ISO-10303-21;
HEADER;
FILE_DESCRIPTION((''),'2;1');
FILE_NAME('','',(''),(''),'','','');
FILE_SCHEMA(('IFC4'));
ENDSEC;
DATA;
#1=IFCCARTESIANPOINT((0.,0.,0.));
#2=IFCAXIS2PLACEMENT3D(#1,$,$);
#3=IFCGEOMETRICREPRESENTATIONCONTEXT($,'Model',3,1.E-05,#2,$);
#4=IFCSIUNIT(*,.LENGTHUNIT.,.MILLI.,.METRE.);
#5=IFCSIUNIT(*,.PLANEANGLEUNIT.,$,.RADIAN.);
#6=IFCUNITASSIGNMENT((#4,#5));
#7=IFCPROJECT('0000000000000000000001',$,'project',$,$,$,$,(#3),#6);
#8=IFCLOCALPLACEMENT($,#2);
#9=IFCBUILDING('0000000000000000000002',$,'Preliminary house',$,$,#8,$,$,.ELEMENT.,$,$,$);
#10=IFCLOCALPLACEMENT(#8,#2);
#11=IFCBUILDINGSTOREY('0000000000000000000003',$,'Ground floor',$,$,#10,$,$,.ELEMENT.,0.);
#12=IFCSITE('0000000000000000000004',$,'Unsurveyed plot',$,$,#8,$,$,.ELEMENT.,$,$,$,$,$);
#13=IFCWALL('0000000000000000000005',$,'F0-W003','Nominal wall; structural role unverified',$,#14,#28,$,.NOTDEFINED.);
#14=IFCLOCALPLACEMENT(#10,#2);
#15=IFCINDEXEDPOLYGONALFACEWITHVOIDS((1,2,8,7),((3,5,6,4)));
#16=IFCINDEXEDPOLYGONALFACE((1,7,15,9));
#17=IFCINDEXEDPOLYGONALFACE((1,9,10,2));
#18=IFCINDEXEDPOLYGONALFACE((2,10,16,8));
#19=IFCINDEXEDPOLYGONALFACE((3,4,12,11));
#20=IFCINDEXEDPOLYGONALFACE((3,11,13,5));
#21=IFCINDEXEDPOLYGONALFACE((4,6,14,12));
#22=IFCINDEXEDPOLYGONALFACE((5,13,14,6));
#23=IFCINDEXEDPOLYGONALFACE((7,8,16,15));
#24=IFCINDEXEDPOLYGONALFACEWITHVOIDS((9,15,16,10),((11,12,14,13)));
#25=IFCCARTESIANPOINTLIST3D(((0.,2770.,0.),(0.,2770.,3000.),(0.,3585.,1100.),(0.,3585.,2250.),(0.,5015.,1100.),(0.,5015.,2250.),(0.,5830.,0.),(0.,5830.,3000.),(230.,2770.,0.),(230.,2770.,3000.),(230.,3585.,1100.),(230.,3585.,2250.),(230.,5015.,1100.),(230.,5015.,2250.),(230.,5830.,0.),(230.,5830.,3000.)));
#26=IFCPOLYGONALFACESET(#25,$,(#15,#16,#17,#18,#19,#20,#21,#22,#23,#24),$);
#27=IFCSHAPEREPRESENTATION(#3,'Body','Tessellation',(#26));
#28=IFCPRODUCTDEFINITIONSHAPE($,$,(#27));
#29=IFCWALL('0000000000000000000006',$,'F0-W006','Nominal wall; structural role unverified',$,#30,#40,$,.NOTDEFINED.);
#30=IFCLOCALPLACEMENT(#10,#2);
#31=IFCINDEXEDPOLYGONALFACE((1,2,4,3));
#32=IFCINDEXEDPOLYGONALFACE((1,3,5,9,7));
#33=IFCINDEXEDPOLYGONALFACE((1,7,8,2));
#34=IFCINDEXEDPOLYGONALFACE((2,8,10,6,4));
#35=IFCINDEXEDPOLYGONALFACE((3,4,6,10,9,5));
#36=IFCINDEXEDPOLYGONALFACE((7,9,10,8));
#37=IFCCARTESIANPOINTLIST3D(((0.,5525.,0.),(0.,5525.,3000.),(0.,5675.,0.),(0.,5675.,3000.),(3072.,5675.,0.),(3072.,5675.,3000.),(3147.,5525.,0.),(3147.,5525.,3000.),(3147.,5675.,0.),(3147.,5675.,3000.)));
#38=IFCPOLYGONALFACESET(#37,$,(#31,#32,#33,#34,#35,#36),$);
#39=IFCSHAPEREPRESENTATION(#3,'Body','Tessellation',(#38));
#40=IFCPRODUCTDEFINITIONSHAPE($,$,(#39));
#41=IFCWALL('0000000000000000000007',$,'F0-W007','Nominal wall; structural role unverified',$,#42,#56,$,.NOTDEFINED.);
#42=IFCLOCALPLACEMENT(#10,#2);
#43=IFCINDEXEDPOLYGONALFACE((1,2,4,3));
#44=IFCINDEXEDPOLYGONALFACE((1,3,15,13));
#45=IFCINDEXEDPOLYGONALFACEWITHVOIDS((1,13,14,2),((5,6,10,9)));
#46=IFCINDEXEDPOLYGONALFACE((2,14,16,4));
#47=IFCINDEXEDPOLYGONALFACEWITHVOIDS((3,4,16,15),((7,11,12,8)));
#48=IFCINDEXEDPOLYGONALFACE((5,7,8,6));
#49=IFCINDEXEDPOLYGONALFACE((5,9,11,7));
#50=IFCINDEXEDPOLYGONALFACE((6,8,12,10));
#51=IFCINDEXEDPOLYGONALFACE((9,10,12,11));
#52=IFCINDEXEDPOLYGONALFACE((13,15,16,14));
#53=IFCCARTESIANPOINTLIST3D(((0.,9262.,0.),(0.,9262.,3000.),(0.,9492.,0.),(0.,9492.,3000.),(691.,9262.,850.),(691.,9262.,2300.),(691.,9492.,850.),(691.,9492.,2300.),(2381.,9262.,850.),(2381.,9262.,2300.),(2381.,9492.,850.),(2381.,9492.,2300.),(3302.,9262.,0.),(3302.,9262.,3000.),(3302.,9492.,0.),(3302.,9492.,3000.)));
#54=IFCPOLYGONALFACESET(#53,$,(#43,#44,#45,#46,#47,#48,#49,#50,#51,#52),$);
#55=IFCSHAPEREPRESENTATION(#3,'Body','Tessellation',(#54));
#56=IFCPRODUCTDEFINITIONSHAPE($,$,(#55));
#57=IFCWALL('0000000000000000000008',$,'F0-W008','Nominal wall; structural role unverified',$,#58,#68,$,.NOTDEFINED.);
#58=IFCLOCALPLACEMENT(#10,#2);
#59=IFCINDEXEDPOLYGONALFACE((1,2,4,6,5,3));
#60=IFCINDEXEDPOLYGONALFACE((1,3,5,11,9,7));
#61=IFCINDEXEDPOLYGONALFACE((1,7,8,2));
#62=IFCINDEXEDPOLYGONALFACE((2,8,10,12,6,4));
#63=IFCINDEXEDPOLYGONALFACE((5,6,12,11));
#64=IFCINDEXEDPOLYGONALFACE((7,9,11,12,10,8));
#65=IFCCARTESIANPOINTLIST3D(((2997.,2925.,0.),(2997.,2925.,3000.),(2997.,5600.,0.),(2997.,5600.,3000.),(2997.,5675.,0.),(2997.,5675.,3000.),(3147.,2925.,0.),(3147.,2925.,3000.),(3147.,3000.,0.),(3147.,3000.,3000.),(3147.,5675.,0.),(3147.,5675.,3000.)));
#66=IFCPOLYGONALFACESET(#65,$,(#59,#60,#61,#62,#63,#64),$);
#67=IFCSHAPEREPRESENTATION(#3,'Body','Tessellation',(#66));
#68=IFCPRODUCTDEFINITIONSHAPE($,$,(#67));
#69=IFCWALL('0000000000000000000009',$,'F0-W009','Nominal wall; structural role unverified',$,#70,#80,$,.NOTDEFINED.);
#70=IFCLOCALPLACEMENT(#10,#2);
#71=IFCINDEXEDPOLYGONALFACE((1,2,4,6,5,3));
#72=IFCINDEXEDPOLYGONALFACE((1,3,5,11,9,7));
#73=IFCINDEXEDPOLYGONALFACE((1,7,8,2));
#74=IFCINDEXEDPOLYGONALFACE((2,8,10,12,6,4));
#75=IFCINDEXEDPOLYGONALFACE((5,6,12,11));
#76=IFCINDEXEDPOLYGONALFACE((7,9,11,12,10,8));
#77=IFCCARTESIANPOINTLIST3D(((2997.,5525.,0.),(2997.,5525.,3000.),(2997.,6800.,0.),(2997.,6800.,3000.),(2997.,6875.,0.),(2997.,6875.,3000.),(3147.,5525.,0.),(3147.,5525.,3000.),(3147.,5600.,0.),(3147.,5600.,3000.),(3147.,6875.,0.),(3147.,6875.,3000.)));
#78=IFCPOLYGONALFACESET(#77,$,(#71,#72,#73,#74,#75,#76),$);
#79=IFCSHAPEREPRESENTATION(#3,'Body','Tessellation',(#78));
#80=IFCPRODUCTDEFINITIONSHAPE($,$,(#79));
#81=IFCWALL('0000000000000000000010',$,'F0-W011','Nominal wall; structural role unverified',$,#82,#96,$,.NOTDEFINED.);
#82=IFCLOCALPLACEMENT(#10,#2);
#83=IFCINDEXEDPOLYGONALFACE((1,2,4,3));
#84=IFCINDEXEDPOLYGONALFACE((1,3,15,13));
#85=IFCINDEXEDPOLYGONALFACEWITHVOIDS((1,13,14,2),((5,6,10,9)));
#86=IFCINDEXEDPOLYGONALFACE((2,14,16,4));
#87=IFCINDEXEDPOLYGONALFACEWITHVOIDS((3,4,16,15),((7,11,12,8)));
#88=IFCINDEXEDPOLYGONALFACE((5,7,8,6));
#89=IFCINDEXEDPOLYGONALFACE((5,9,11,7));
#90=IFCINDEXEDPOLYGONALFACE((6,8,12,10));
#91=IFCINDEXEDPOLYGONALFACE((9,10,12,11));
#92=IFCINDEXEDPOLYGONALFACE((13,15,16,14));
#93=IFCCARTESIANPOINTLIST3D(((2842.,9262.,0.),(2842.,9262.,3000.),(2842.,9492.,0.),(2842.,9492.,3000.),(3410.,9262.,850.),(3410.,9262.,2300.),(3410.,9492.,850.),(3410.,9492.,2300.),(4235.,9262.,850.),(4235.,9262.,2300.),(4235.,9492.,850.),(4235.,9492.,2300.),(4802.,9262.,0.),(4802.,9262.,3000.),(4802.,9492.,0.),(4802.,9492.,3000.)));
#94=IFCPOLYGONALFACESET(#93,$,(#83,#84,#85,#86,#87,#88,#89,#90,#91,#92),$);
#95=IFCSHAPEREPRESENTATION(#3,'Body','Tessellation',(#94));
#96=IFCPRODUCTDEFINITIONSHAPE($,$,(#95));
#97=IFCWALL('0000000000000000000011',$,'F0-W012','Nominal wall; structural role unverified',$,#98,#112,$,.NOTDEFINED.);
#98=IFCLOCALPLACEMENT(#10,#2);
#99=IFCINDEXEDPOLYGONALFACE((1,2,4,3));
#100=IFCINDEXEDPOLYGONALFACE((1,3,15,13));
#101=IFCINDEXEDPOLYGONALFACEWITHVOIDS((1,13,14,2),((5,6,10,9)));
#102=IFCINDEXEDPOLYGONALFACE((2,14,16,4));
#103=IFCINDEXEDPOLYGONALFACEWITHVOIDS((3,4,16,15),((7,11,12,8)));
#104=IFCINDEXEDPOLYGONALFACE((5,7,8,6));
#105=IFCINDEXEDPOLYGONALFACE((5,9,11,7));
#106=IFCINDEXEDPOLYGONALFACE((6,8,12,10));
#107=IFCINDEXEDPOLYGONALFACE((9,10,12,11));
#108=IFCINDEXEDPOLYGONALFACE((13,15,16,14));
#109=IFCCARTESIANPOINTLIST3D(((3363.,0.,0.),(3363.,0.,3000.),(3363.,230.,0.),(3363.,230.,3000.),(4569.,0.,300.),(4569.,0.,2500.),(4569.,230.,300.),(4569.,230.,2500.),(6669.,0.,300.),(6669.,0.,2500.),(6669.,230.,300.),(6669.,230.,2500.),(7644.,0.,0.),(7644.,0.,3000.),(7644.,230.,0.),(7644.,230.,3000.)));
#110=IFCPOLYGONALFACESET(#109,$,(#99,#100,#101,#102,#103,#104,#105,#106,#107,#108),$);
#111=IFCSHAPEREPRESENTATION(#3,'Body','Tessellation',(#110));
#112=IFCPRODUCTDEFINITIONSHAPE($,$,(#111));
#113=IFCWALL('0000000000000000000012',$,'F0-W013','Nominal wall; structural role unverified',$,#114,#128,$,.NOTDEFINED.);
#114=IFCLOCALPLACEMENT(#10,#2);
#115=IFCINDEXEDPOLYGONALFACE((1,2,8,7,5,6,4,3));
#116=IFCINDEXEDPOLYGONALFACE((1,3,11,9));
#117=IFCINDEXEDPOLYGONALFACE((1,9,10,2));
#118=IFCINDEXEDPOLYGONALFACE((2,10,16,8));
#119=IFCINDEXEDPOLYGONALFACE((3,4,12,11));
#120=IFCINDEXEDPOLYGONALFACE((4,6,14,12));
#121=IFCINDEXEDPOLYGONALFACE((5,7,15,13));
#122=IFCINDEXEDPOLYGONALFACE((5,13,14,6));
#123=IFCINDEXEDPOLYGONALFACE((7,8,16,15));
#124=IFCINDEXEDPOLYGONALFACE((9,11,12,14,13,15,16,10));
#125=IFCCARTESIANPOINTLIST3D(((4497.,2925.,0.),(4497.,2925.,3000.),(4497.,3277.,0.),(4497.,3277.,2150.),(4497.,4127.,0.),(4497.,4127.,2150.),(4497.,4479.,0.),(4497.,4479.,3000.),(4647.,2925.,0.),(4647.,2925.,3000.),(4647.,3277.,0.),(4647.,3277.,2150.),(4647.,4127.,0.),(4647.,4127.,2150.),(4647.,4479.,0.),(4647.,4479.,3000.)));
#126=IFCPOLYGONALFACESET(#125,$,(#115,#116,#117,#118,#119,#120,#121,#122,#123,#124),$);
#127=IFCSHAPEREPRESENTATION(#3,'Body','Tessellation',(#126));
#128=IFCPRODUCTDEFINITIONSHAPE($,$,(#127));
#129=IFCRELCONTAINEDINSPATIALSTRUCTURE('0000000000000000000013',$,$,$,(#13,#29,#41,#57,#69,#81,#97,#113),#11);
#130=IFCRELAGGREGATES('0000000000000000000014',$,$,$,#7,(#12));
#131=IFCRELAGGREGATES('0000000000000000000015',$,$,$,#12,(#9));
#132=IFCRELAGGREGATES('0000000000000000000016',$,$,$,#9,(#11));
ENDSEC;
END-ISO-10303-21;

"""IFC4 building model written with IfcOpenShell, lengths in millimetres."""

from ifc_helpers import new_model, si_unit, frame, origin, place, context, project, spatial, polyline, outline, extrude, element, save


model = new_model("IFC4")

# Units and contexts
model_context = context("Model", 3, precision=1e-05, world=origin())
ifc_project = project(units=[si_unit("LENGTHUNIT", "METRE", prefix="MILLI"), si_unit("PLANEANGLEUNIT", "RADIAN")], contexts=[model_context])

# Site, building, storey
placement_1 = place(None, origin())
site = spatial("IfcSite", under=ifc_project, at=placement_1, Name="Unsurveyed plot", CompositionType="ELEMENT")
building = spatial("IfcBuilding", under=site, at=placement_1, Name="Preliminary house", CompositionType="ELEMENT")
placement_2 = place(placement_1, origin())
storey = spatial("IfcBuildingStorey", under=building, at=placement_2, Name="Ground floor", CompositionType="ELEMENT", Elevation=0.0)

# Wall, opening
wall_1 = element("IfcWall", 1, at=placement_2, inside=storey, Name="F0-W003", Description="Nominal wall; structural role unverified", PredefinedType="NOTDEFINED", context=model_context, shape_type="SweptSolid", body=[
    extrude(outline(polyline([(230.0, 5830.0), (230.0, 3000.0), (230.0, 2770.0), (0.0, 2770.0), (0.0, 5830.0), (230.0, 5830.0)])), origin(), (0.0, 0.0, 1.0), 3000.0),
])
element("IfcOpeningElement", 2, at=placement_2, cuts=wall_1, PredefinedType="OPENING", context=model_context, shape_type="SweptSolid", body=[
    extrude(outline(polyline([(645.0, 3585.0), (645.0, 5015.0), (-415.0, 5015.0), (-415.0, 3585.0), (645.0, 3585.0)])), frame((0.0, 0.0, 1100.0)), (0.0, 0.0, 1.0), 1150.0),
])

# Wall
element("IfcWall", 3, at=placement_2, inside=storey, Name="F0-W006", Description="Nominal wall; structural role unverified", PredefinedType="NOTDEFINED", context=model_context, shape_type="SweptSolid", body=[
    extrude(outline(polyline([(3147.0, 5675.0), (3147.0, 5525.0), (0.0, 5525.0), (0.0, 5675.0), (3072.0, 5675.0), (3147.0, 5675.0)])), origin(), (0.0, 0.0, 1.0), 3000.0),
])

# Wall, opening
wall_2 = element("IfcWall", 4, at=placement_2, inside=storey, Name="F0-W007", Description="Nominal wall; structural role unverified", PredefinedType="NOTDEFINED", context=model_context, shape_type="SweptSolid", body=[
    extrude(outline(polyline([(3302.0, 9262.0), (0.0, 9262.0), (0.0, 9492.0), (3302.0, 9492.0), (3302.0, 9262.0)])), origin(), (0.0, 0.0, 1.0), 3000.0),
])
element("IfcOpeningElement", 5, at=placement_2, cuts=wall_2, PredefinedType="OPENING", context=model_context, shape_type="SweptSolid", body=[
    extrude(outline(polyline([(691.0, 8847.0), (2381.0, 8847.0), (2381.0, 9907.0), (691.0, 9907.0), (691.0, 8847.0)])), frame((0.0, 0.0, 850.0)), (0.0, 0.0, 1.0), 1450.0),
])

# Walls
element("IfcWall", 6, at=placement_2, inside=storey, Name="F0-W008", Description="Nominal wall; structural role unverified", PredefinedType="NOTDEFINED", context=model_context, shape_type="SweptSolid", body=[
    extrude(outline(polyline([(2997.0, 5675.0), (3147.0, 5675.0), (3147.0, 3000.0), (3147.0, 2925.0), (2997.0, 2925.0), (2997.0, 5600.0), (2997.0, 5675.0)])), origin(), (0.0, 0.0, 1.0), 3000.0),
])
element("IfcWall", 7, at=placement_2, inside=storey, Name="F0-W009", Description="Nominal wall; structural role unverified", PredefinedType="NOTDEFINED", context=model_context, shape_type="SweptSolid", body=[
    extrude(outline(polyline([(2997.0, 6875.0), (3147.0, 6875.0), (3147.0, 5600.0), (3147.0, 5525.0), (2997.0, 5525.0), (2997.0, 6800.0), (2997.0, 6875.0)])), origin(), (0.0, 0.0, 1.0), 3000.0),
])

# Walls, openings
wall_3 = element("IfcWall", 8, at=placement_2, inside=storey, Name="F0-W011", Description="Nominal wall; structural role unverified", PredefinedType="NOTDEFINED", context=model_context, shape_type="SweptSolid", body=[
    extrude(outline(polyline([(4802.0, 9262.0), (3072.0, 9262.0), (2842.0, 9262.0), (2842.0, 9492.0), (4802.0, 9492.0), (4802.0, 9262.0)])), origin(), (0.0, 0.0, 1.0), 3000.0),
])
element("IfcOpeningElement", 9, at=placement_2, cuts=wall_3, PredefinedType="OPENING", context=model_context, shape_type="SweptSolid", body=[
    extrude(outline(polyline([(3410.0, 8847.0), (4235.0, 8847.0), (4235.0, 9907.0), (3410.0, 9907.0), (3410.0, 8847.0)])), frame((0.0, 0.0, 850.0)), (0.0, 0.0, 1.0), 1450.0),
])
wall_4 = element("IfcWall", 10, at=placement_2, inside=storey, Name="F0-W012", Description="Nominal wall; structural role unverified", PredefinedType="NOTDEFINED", context=model_context, shape_type="SweptSolid", body=[
    extrude(outline(polyline([(3363.0, 230.0), (7644.0, 230.0), (7644.0, 0.0), (3363.0, 0.0), (3363.0, 230.0)])), origin(), (0.0, 0.0, 1.0), 3000.0),
])
element("IfcOpeningElement", 11, at=placement_2, cuts=wall_4, PredefinedType="OPENING", context=model_context, shape_type="SweptSolid", body=[
    extrude(outline(polyline([(4569.0, -415.0), (6669.0, -415.0), (6669.0, 645.0), (4569.0, 645.0), (4569.0, -415.0)])), frame((0.0, 0.0, 300.0)), (0.0, 0.0, 1.0), 2200.0),
])
wall_5 = element("IfcWall", 12, at=placement_2, inside=storey, Name="F0-W013", Description="Nominal wall; structural role unverified", PredefinedType="NOTDEFINED", context=model_context, shape_type="SweptSolid", body=[
    extrude(outline(polyline([(4497.0, 4479.0), (4647.0, 4479.0), (4647.0, 3000.0), (4647.0, 2925.0), (4497.0, 2925.0), (4497.0, 4404.0), (4497.0, 4479.0)])), origin(), (0.0, 0.0, 1.0), 3000.0),
])
element("IfcOpeningElement", 13, at=placement_2, cuts=wall_5, PredefinedType="OPENING", context=model_context, shape_type="SweptSolid", body=[
    extrude(outline(polyline([(5022.0, 3277.0), (5022.0, 4127.0), (4122.0, 4127.0), (4122.0, 3277.0), (5022.0, 3277.0)])), origin(), (0.0, 0.0, 1.0), 2150.0),
])

save(model, "model.ifc")
